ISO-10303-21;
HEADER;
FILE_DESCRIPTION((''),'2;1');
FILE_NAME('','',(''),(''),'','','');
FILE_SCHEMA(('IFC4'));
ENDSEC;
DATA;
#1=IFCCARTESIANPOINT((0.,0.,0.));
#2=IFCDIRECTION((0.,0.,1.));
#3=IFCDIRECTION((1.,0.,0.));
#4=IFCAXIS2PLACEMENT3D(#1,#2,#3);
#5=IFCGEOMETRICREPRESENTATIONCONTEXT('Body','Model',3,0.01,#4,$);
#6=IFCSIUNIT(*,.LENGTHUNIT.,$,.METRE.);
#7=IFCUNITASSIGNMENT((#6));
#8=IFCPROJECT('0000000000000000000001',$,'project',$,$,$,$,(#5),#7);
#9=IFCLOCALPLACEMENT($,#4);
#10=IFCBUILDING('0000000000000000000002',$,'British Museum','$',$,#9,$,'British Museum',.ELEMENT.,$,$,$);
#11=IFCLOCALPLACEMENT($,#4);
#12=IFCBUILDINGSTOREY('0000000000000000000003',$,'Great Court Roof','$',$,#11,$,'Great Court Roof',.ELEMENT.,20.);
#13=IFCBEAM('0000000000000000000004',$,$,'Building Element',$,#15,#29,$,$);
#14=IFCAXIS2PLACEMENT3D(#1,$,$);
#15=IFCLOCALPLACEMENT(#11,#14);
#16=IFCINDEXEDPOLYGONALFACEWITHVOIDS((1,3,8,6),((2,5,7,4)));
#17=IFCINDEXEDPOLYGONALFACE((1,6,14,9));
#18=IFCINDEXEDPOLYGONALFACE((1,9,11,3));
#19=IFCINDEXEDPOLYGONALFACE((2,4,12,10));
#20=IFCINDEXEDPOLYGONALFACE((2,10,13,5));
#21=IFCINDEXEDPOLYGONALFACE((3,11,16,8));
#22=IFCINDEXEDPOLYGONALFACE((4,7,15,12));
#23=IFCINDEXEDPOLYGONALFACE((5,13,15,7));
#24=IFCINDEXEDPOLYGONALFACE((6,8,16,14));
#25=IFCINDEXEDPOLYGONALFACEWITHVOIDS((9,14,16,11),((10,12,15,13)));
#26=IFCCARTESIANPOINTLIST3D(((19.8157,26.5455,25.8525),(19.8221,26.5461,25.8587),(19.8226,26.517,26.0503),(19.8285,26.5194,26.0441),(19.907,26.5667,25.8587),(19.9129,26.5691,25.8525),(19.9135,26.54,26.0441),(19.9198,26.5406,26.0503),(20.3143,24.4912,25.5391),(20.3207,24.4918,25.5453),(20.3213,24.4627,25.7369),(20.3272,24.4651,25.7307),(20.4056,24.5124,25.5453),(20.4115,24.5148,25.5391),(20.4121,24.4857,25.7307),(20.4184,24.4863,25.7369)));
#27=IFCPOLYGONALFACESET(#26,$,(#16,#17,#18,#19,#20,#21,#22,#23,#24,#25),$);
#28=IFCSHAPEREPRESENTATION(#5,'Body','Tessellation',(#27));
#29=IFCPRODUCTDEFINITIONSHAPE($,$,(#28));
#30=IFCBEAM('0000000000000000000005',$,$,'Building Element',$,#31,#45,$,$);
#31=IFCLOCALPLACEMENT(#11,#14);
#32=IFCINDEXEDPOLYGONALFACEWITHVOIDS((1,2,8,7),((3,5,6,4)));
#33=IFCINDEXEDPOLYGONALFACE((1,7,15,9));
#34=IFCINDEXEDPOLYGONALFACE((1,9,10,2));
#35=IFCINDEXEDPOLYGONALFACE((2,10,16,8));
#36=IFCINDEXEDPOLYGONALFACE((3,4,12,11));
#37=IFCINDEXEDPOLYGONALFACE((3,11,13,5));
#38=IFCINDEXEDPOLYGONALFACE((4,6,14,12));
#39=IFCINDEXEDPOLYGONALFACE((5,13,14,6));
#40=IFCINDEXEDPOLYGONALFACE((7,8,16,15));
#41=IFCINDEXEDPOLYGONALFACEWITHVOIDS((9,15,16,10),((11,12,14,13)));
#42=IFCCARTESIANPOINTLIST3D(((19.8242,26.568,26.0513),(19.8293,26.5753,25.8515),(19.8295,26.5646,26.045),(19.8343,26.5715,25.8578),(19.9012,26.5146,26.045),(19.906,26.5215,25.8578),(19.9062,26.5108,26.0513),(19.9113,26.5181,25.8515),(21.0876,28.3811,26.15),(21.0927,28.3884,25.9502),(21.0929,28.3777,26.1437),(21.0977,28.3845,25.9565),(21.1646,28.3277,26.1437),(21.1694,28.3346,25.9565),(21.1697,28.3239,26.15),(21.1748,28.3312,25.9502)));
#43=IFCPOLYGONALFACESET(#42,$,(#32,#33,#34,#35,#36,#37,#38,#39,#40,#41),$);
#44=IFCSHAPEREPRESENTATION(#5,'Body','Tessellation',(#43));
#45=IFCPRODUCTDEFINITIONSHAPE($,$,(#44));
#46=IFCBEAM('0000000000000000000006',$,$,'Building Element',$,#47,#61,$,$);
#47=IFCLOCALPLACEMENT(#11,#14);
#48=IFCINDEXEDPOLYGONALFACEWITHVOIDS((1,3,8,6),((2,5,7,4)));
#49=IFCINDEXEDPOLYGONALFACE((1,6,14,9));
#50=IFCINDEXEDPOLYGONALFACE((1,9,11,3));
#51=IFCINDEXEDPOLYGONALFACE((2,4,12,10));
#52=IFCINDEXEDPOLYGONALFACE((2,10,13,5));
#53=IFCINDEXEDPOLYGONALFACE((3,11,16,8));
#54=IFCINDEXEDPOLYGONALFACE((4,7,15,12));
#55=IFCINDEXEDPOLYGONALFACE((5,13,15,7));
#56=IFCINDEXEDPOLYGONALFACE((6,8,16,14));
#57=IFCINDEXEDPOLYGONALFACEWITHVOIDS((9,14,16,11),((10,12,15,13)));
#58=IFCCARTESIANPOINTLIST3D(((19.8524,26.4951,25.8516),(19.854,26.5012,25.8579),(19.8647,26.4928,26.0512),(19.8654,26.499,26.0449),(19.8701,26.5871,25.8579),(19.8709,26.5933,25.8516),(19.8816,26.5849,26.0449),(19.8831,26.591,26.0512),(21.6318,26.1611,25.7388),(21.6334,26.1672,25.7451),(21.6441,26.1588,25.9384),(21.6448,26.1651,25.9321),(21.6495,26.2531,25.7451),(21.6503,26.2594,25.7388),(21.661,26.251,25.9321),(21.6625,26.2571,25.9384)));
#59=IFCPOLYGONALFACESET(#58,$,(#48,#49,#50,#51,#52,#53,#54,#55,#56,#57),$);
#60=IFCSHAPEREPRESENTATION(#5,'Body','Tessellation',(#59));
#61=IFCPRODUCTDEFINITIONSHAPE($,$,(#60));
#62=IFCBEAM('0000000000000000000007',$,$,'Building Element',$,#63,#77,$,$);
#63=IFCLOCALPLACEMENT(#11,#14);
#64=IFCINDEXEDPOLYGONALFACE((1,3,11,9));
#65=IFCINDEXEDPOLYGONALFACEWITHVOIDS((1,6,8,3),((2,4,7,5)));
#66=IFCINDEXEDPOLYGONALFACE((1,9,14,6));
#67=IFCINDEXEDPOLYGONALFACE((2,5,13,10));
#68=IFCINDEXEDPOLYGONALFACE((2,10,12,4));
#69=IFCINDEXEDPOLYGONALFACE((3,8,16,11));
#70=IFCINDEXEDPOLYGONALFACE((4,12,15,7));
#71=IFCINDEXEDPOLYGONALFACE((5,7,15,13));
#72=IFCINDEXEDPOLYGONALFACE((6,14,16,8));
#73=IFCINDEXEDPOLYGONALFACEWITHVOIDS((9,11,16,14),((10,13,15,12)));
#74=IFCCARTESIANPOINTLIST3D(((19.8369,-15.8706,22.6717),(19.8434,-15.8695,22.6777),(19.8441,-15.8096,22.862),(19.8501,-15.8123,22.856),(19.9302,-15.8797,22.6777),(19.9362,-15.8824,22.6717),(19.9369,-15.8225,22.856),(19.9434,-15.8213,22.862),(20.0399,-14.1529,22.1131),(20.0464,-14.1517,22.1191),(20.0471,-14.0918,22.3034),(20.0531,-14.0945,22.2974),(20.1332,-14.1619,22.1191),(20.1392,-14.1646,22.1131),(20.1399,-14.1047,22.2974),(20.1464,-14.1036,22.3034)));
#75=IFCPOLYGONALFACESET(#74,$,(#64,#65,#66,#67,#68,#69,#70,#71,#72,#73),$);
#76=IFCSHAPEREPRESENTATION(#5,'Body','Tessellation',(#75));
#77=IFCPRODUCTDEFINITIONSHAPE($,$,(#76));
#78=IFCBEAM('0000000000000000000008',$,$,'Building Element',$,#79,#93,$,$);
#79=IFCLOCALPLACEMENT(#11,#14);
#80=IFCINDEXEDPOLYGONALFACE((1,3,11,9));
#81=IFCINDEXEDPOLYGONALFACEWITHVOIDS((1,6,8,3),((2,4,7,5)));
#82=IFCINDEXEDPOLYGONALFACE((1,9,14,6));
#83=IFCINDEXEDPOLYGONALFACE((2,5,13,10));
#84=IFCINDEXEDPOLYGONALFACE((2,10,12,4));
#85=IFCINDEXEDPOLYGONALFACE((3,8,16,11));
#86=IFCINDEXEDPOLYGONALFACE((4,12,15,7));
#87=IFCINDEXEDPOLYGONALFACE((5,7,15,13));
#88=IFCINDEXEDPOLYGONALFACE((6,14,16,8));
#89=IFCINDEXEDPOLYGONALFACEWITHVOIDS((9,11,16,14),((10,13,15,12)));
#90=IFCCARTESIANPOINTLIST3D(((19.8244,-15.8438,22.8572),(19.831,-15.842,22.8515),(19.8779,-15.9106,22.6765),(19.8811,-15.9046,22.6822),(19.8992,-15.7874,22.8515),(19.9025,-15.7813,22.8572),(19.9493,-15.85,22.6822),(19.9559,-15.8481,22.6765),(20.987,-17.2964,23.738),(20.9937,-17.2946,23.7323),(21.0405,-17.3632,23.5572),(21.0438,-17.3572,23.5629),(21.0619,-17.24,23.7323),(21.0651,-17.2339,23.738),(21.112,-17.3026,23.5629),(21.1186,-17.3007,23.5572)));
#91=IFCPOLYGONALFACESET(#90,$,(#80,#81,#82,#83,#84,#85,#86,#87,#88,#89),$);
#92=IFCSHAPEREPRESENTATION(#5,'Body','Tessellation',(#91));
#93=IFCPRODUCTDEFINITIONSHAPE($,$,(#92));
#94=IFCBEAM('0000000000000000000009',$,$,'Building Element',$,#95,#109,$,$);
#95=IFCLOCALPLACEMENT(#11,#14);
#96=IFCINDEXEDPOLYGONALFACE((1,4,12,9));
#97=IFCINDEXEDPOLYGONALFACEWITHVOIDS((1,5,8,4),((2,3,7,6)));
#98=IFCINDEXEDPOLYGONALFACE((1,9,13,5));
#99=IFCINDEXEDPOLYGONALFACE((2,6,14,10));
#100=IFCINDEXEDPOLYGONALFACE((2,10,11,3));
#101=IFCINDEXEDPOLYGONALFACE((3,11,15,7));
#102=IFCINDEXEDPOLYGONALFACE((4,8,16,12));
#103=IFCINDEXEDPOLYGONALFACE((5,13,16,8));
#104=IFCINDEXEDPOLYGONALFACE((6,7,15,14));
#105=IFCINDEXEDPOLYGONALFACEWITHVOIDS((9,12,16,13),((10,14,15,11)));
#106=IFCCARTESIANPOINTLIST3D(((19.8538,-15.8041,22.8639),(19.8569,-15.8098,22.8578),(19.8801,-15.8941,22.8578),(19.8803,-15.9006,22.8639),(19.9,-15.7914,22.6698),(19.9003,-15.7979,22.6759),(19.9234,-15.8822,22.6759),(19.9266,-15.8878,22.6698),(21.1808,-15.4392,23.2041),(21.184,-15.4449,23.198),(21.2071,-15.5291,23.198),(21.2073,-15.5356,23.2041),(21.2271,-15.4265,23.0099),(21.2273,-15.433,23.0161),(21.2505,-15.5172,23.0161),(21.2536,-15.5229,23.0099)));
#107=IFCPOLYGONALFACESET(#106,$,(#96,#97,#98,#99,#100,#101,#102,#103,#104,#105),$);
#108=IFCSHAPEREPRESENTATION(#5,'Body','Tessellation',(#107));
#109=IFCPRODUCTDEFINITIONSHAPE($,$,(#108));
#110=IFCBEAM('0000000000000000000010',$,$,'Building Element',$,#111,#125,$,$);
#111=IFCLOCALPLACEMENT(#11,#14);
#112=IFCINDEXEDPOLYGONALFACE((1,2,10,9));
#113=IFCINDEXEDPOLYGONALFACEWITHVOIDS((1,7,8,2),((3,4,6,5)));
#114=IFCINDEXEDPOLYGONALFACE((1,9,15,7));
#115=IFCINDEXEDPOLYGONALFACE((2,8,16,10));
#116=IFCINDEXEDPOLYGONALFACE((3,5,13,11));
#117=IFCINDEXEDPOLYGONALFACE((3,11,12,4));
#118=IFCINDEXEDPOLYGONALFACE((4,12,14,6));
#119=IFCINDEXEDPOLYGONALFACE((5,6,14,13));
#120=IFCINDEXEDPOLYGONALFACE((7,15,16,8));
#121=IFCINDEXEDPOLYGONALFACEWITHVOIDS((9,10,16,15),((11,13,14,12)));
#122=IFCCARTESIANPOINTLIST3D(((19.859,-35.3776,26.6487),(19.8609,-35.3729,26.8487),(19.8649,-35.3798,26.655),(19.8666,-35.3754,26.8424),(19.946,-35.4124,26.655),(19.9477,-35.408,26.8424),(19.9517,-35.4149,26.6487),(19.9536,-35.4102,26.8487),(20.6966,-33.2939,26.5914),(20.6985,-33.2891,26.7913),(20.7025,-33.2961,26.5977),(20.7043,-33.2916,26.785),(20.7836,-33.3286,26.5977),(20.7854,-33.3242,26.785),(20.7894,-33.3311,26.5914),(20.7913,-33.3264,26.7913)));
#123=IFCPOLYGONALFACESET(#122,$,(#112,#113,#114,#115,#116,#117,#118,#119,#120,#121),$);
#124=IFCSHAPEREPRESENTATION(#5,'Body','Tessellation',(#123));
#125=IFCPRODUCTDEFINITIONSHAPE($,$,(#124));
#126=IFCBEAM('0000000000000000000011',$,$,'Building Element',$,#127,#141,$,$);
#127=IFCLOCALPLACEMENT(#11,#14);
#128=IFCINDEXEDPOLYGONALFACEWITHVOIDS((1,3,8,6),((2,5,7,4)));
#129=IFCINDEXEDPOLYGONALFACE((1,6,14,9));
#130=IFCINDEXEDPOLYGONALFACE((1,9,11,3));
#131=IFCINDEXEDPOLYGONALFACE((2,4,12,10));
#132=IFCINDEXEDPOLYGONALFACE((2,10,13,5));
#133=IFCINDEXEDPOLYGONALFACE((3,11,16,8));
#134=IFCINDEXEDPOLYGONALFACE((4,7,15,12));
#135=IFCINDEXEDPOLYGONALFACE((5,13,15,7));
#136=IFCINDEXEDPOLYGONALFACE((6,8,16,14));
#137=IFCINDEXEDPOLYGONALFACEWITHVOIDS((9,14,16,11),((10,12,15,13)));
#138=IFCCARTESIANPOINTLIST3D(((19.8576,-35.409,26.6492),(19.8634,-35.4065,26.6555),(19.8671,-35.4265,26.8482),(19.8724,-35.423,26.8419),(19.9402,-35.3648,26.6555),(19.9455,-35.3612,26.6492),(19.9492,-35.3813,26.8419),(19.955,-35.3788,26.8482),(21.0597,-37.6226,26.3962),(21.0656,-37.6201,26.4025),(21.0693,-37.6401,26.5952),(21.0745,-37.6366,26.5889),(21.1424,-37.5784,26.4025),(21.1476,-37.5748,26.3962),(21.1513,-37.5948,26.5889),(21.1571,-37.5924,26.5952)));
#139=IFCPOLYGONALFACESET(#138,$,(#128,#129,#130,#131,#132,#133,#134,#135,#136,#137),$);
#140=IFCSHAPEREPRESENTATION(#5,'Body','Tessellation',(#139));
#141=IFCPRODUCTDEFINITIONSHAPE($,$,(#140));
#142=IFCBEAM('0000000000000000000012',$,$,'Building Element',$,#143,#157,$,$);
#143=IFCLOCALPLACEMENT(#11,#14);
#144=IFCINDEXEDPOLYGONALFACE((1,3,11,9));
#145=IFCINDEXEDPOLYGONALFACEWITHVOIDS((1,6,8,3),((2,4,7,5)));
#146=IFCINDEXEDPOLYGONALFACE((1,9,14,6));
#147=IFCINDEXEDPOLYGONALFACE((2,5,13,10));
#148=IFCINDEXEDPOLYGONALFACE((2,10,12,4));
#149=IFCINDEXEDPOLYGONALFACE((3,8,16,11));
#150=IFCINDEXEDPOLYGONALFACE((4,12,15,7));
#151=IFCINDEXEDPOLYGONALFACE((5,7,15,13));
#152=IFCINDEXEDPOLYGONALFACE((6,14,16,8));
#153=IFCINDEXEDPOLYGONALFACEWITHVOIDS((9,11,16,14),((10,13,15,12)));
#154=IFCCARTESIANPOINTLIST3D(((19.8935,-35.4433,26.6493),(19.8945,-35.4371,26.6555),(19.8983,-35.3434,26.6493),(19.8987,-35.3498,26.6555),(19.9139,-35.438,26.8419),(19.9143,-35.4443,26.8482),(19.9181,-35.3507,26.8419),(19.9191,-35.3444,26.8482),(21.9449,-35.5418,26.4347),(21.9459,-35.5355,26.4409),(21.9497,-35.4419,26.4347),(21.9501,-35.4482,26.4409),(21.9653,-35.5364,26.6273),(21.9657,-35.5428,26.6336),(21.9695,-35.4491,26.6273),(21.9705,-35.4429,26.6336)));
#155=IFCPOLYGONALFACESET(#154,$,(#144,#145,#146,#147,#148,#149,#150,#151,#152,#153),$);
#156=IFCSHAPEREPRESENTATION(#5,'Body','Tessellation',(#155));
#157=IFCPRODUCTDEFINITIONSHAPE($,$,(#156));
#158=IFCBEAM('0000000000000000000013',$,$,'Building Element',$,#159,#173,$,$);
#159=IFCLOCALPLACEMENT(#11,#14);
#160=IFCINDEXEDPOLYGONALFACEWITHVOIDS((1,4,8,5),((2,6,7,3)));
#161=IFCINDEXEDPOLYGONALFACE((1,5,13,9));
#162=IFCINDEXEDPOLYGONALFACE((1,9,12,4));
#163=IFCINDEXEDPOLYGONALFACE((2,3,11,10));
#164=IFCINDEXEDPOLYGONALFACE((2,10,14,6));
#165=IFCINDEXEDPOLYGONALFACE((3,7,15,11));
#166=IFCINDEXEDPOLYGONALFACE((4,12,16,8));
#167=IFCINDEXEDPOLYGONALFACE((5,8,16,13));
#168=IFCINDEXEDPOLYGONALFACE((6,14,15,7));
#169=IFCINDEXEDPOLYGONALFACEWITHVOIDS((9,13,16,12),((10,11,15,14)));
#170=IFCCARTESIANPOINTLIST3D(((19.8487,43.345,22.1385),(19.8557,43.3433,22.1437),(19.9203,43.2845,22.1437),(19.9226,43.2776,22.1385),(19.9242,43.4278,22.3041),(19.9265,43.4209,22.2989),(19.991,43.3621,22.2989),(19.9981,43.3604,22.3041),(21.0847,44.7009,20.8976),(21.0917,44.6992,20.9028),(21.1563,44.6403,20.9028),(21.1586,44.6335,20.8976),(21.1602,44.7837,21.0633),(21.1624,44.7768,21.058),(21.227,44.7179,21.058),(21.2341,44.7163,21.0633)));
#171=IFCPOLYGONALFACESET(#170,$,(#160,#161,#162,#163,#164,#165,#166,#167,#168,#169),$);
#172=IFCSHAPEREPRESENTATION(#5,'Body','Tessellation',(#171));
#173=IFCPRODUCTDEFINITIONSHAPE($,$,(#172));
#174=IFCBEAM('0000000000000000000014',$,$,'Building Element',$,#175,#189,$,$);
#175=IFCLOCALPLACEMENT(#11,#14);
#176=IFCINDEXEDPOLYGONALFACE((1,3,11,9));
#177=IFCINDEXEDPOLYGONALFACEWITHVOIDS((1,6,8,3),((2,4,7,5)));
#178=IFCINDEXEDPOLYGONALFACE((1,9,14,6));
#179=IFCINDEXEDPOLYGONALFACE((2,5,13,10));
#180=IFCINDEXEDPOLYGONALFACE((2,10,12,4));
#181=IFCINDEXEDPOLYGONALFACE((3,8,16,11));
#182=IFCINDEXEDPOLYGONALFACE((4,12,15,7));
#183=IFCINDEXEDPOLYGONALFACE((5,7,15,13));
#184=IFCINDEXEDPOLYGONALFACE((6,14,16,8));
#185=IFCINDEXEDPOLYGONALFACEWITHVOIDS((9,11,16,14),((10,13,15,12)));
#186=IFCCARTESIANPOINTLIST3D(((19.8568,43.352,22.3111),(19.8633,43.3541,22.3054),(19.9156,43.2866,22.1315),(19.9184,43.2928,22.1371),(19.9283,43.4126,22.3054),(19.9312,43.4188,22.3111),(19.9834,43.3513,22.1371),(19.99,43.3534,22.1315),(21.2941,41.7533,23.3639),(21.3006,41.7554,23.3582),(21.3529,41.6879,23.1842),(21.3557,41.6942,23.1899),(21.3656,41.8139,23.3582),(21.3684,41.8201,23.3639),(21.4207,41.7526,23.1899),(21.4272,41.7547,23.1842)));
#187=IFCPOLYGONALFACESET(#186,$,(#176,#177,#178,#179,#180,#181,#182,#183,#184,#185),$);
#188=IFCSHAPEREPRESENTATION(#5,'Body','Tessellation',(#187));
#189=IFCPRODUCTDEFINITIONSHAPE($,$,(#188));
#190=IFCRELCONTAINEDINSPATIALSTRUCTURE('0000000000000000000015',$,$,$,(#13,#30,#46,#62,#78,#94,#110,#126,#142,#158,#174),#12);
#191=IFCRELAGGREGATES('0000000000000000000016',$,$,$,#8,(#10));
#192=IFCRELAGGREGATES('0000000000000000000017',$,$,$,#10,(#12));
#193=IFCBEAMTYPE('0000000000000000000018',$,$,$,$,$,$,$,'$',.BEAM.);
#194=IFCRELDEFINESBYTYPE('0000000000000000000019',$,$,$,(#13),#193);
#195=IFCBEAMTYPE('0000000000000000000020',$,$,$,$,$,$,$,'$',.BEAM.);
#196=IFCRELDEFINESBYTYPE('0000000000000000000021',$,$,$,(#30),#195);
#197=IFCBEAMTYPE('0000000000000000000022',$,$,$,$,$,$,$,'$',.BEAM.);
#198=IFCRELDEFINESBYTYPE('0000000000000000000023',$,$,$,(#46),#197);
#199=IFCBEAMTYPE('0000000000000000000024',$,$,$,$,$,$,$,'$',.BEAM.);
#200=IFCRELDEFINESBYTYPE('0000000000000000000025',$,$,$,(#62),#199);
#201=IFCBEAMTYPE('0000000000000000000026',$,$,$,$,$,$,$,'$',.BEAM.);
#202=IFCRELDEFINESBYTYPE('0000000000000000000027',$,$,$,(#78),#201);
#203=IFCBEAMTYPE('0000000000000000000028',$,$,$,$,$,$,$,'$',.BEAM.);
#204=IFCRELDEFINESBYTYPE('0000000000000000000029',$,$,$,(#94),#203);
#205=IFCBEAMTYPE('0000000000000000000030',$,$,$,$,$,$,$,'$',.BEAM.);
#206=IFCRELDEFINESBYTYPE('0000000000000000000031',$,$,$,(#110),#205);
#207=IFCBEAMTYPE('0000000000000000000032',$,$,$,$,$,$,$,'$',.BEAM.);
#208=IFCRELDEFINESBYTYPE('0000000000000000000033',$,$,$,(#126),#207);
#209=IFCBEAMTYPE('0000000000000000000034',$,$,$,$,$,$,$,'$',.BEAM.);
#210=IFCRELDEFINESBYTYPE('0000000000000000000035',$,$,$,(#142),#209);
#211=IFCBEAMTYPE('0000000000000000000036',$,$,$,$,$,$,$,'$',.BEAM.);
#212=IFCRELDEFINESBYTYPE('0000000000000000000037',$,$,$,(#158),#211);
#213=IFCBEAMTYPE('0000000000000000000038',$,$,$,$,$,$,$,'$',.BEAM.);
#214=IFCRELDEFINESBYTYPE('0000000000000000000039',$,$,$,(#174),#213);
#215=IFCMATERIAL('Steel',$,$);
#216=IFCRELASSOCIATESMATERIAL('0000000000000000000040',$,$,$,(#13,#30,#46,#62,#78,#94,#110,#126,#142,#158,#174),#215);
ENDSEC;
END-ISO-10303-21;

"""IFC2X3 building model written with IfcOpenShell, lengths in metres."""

from ifc_helpers import new_model, si_unit, frame, origin_with_axes, origin_2d, place, context, project, spatial, hollow_rectangle, extrude, material, type_object, element, save


model = new_model("IFC2X3")

# Units and contexts
model_context = context("Model", 3, precision=0.01, world=origin_with_axes(), identifier="Body")
ifc_project = project(units=[si_unit("LENGTHUNIT", "METRE")], contexts=[model_context])

# Building, storey
building_placement = place(None, origin_with_axes())
building = spatial("IfcBuilding", under=ifc_project, at=building_placement, Name="British Museum", Description="$", LongName="British Museum", CompositionType="ELEMENT")
storey_placement = place(None, origin_with_axes())
storey = spatial("IfcBuildingStorey", under=building, at=storey_placement, Name="Great Court Roof", Description="$", LongName="Great Court Roof", CompositionType="ELEMENT", Elevation=20.0)

# Beams
ifc_material = material(Name="Steel")
beam_type_1 = type_object("IfcBeamType", ElementType="$", PredefinedType="BEAM")
beam_1_placement = place(None, origin_with_axes())
element("IfcBeam", 1, at=beam_1_placement, inside=storey, type_object=beam_type_1, material=ifc_material, Description="Building Element", context=model_context, shape_type="SweptSolid", body=[
    extrude(hollow_rectangle(XDim=0.1, YDim=0.2, WallThickness=0.0063, InnerFilletRadius=-0.0063, OuterFilletRadius=0.0, at=origin_2d()), frame((19.8678, 26.543, 25.9514), z_axis=(0.233326, -0.961276, -0.146656), x_axis=(0.971783, 0.235876, 0.0)), (0.0, 0.0, 1.0), 2.137),
])
beam_type_2 = type_object("IfcBeamType", ElementType="$", PredefinedType="BEAM")
beam_2_placement = place(None, origin_with_axes())
element("IfcBeam", 2, at=beam_2_placement, inside=storey, type_object=beam_type_2, material=ifc_material, Description="Building Element", context=model_context, shape_type="SweptSolid", body=[
    extrude(hollow_rectangle(XDim=0.1, YDim=0.2, WallThickness=0.0063, InnerFilletRadius=-0.0063, OuterFilletRadius=0.0, at=origin_2d()), frame((19.8678, 26.543, 25.9514), z_axis=(0.571147, 0.819634, 0.044612), x_axis=(-0.820451, 0.571717, 0.0)), (0.0, 0.0, 1.0), 2.2121),
])
beam_type_3 = type_object("IfcBeamType", ElementType="$", PredefinedType="BEAM")
beam_3_placement = place(None, origin_with_axes())
element("IfcBeam", 3, at=beam_3_placement, inside=storey, type_object=beam_type_3, material=ifc_material, Description="Building Element", context=model_context, shape_type="SweptSolid", body=[
    extrude(hollow_rectangle(XDim=0.1, YDim=0.2, WallThickness=0.0063, InnerFilletRadius=-0.0063, OuterFilletRadius=0.0, at=origin_2d()), frame((19.8678, 26.543, 25.9514), z_axis=(0.980939, -0.184093, -0.062195), x_axis=(0.18445, 0.982842, 0.0)), (0.0, 0.0, 1.0), 1.814),
])
beam_type_4 = type_object("IfcBeamType", ElementType="$", PredefinedType="BEAM")
beam_4_placement = place(None, origin_with_axes())
element("IfcBeam", 4, at=beam_4_placement, inside=storey, type_object=beam_type_4, material=ifc_material, Description="Building Element", context=model_context, shape_type="SweptSolid", body=[
    extrude(hollow_rectangle(XDim=0.1, YDim=0.2, WallThickness=0.0063, InnerFilletRadius=-0.0063, OuterFilletRadius=0.0, at=origin_2d()), frame((19.8902, -15.846, 22.7669), z_axis=(0.111677, 0.94503, -0.307321), x_axis=(-0.99309, 0.117357, 0.0)), (0.0, 0.0, 1.0), 1.8177),
])
beam_type_5 = type_object("IfcBeamType", ElementType="$", PredefinedType="BEAM")
beam_5_placement = place(None, origin_with_axes())
element("IfcBeam", 5, at=beam_5_placement, inside=storey, type_object=beam_type_5, material=ifc_material, Description="Building Element", context=model_context, shape_type="SweptSolid", body=[
    extrude(hollow_rectangle(XDim=0.1, YDim=0.2, WallThickness=0.0063, InnerFilletRadius=-0.0063, OuterFilletRadius=0.0, at=origin_2d()), frame((19.8902, -15.846, 22.7669), z_axis=(0.564807, -0.70565, 0.427846), x_axis=(0.780714, 0.624889, 0.0)), (0.0, 0.0, 1.0), 2.0585),
])
beam_type_6 = type_object("IfcBeamType", ElementType="$", PredefinedType="BEAM")
beam_6_placement = place(None, origin_with_axes())
element("IfcBeam", 6, at=beam_6_placement, inside=storey, type_object=beam_type_6, material=ifc_material, Description="Building Element", context=model_context, shape_type="SweptSolid", body=[
    extrude(hollow_rectangle(XDim=0.1, YDim=0.2, WallThickness=0.0063, InnerFilletRadius=-0.0063, OuterFilletRadius=0.0, at=origin_2d()), frame((19.8902, -15.846, 22.7669), z_axis=(0.936039, 0.257406, 0.239943), x_axis=(-0.265152, 0.964207, 0.0)), (0.0, 0.0, 1.0), 1.4177),
])
beam_type_7 = type_object("IfcBeamType", ElementType="$", PredefinedType="BEAM")
beam_7_placement = place(None, origin_with_axes())
element("IfcBeam", 7, at=beam_7_placement, inside=storey, type_object=beam_type_7, material=ifc_material, Description="Building Element", context=model_context, shape_type="SweptSolid", body=[
    extrude(hollow_rectangle(XDim=0.1, YDim=0.2, WallThickness=0.0063, InnerFilletRadius=-0.0063, OuterFilletRadius=0.0, at=origin_2d()), frame((19.9063, -35.3939, 26.7487), z_axis=(0.372851, 0.92754, -0.025522), x_axis=(-0.927842, 0.372973, 0.0)), (0.0, 0.0, 1.0), 2.2465),
])
beam_type_8 = type_object("IfcBeamType", ElementType="$", PredefinedType="BEAM")
beam_8_placement = place(None, origin_with_axes())
element("IfcBeam", 8, at=beam_8_placement, inside=storey, type_object=beam_type_8, material=ifc_material, Description="Building Element", context=model_context, shape_type="SweptSolid", body=[
    extrude(hollow_rectangle(XDim=0.1, YDim=0.2, WallThickness=0.0063, InnerFilletRadius=-0.0063, OuterFilletRadius=0.0, at=origin_2d()), frame((19.9063, -35.3939, 26.7487), z_axis=(0.474843, -0.874378, -0.099935), x_axis=(0.878777, 0.477232, 0.0)), (0.0, 0.0, 1.0), 2.5316),
])
beam_type_9 = type_object("IfcBeamType", ElementType="$", PredefinedType="BEAM")
beam_9_placement = place(None, origin_with_axes())
element("IfcBeam", 9, at=beam_9_placement, inside=storey, type_object=beam_type_9, material=ifc_material, Description="Building Element", context=model_context, shape_type="SweptSolid", body=[
    extrude(hollow_rectangle(XDim=0.1, YDim=0.2, WallThickness=0.0063, InnerFilletRadius=-0.0063, OuterFilletRadius=0.0, at=origin_2d()), frame((19.9063, -35.3939, 26.7487), z_axis=(0.993443, -0.047677, -0.103913), x_axis=(0.047937, 0.99885, 0.0)), (0.0, 0.0, 1.0), 2.0649),
])
beam_type_10 = type_object("IfcBeamType", ElementType="$", PredefinedType="BEAM")
beam_10_placement = place(None, origin_with_axes())
element("IfcBeam", 10, at=beam_10_placement, inside=storey, type_object=beam_type_10, material=ifc_material, Description="Building Element", context=model_context, shape_type="SweptSolid", body=[
    extrude(hollow_rectangle(XDim=0.1, YDim=0.2, WallThickness=0.0063, InnerFilletRadius=-0.0063, OuterFilletRadius=0.0, at=origin_2d()), frame((19.9234, 43.3527, 22.2213), z_axis=(0.558033, 0.612155, -0.560237), x_axis=(-0.739021, 0.673682, 0.0)), (0.0, 0.0, 1.0), 2.2149),
])
beam_type_11 = type_object("IfcBeamType", ElementType="$", PredefinedType="BEAM")
beam_11_placement = place(None, origin_with_axes())
element("IfcBeam", 11, at=beam_11_placement, inside=storey, type_object=beam_type_11, material=ifc_material, Description="Building Element", context=model_context, shape_type="SweptSolid", body=[
    extrude(hollow_rectangle(XDim=0.1, YDim=0.2, WallThickness=0.0063, InnerFilletRadius=-0.0063, OuterFilletRadius=0.0, at=origin_2d()), frame((19.9234, 43.3527, 22.2213), z_axis=(0.600435, -0.667871, 0.439802), x_axis=(0.743653, 0.668565, 0.0)), (0.0, 0.0, 1.0), 2.3937),
])

save(model, "model.ifc")
